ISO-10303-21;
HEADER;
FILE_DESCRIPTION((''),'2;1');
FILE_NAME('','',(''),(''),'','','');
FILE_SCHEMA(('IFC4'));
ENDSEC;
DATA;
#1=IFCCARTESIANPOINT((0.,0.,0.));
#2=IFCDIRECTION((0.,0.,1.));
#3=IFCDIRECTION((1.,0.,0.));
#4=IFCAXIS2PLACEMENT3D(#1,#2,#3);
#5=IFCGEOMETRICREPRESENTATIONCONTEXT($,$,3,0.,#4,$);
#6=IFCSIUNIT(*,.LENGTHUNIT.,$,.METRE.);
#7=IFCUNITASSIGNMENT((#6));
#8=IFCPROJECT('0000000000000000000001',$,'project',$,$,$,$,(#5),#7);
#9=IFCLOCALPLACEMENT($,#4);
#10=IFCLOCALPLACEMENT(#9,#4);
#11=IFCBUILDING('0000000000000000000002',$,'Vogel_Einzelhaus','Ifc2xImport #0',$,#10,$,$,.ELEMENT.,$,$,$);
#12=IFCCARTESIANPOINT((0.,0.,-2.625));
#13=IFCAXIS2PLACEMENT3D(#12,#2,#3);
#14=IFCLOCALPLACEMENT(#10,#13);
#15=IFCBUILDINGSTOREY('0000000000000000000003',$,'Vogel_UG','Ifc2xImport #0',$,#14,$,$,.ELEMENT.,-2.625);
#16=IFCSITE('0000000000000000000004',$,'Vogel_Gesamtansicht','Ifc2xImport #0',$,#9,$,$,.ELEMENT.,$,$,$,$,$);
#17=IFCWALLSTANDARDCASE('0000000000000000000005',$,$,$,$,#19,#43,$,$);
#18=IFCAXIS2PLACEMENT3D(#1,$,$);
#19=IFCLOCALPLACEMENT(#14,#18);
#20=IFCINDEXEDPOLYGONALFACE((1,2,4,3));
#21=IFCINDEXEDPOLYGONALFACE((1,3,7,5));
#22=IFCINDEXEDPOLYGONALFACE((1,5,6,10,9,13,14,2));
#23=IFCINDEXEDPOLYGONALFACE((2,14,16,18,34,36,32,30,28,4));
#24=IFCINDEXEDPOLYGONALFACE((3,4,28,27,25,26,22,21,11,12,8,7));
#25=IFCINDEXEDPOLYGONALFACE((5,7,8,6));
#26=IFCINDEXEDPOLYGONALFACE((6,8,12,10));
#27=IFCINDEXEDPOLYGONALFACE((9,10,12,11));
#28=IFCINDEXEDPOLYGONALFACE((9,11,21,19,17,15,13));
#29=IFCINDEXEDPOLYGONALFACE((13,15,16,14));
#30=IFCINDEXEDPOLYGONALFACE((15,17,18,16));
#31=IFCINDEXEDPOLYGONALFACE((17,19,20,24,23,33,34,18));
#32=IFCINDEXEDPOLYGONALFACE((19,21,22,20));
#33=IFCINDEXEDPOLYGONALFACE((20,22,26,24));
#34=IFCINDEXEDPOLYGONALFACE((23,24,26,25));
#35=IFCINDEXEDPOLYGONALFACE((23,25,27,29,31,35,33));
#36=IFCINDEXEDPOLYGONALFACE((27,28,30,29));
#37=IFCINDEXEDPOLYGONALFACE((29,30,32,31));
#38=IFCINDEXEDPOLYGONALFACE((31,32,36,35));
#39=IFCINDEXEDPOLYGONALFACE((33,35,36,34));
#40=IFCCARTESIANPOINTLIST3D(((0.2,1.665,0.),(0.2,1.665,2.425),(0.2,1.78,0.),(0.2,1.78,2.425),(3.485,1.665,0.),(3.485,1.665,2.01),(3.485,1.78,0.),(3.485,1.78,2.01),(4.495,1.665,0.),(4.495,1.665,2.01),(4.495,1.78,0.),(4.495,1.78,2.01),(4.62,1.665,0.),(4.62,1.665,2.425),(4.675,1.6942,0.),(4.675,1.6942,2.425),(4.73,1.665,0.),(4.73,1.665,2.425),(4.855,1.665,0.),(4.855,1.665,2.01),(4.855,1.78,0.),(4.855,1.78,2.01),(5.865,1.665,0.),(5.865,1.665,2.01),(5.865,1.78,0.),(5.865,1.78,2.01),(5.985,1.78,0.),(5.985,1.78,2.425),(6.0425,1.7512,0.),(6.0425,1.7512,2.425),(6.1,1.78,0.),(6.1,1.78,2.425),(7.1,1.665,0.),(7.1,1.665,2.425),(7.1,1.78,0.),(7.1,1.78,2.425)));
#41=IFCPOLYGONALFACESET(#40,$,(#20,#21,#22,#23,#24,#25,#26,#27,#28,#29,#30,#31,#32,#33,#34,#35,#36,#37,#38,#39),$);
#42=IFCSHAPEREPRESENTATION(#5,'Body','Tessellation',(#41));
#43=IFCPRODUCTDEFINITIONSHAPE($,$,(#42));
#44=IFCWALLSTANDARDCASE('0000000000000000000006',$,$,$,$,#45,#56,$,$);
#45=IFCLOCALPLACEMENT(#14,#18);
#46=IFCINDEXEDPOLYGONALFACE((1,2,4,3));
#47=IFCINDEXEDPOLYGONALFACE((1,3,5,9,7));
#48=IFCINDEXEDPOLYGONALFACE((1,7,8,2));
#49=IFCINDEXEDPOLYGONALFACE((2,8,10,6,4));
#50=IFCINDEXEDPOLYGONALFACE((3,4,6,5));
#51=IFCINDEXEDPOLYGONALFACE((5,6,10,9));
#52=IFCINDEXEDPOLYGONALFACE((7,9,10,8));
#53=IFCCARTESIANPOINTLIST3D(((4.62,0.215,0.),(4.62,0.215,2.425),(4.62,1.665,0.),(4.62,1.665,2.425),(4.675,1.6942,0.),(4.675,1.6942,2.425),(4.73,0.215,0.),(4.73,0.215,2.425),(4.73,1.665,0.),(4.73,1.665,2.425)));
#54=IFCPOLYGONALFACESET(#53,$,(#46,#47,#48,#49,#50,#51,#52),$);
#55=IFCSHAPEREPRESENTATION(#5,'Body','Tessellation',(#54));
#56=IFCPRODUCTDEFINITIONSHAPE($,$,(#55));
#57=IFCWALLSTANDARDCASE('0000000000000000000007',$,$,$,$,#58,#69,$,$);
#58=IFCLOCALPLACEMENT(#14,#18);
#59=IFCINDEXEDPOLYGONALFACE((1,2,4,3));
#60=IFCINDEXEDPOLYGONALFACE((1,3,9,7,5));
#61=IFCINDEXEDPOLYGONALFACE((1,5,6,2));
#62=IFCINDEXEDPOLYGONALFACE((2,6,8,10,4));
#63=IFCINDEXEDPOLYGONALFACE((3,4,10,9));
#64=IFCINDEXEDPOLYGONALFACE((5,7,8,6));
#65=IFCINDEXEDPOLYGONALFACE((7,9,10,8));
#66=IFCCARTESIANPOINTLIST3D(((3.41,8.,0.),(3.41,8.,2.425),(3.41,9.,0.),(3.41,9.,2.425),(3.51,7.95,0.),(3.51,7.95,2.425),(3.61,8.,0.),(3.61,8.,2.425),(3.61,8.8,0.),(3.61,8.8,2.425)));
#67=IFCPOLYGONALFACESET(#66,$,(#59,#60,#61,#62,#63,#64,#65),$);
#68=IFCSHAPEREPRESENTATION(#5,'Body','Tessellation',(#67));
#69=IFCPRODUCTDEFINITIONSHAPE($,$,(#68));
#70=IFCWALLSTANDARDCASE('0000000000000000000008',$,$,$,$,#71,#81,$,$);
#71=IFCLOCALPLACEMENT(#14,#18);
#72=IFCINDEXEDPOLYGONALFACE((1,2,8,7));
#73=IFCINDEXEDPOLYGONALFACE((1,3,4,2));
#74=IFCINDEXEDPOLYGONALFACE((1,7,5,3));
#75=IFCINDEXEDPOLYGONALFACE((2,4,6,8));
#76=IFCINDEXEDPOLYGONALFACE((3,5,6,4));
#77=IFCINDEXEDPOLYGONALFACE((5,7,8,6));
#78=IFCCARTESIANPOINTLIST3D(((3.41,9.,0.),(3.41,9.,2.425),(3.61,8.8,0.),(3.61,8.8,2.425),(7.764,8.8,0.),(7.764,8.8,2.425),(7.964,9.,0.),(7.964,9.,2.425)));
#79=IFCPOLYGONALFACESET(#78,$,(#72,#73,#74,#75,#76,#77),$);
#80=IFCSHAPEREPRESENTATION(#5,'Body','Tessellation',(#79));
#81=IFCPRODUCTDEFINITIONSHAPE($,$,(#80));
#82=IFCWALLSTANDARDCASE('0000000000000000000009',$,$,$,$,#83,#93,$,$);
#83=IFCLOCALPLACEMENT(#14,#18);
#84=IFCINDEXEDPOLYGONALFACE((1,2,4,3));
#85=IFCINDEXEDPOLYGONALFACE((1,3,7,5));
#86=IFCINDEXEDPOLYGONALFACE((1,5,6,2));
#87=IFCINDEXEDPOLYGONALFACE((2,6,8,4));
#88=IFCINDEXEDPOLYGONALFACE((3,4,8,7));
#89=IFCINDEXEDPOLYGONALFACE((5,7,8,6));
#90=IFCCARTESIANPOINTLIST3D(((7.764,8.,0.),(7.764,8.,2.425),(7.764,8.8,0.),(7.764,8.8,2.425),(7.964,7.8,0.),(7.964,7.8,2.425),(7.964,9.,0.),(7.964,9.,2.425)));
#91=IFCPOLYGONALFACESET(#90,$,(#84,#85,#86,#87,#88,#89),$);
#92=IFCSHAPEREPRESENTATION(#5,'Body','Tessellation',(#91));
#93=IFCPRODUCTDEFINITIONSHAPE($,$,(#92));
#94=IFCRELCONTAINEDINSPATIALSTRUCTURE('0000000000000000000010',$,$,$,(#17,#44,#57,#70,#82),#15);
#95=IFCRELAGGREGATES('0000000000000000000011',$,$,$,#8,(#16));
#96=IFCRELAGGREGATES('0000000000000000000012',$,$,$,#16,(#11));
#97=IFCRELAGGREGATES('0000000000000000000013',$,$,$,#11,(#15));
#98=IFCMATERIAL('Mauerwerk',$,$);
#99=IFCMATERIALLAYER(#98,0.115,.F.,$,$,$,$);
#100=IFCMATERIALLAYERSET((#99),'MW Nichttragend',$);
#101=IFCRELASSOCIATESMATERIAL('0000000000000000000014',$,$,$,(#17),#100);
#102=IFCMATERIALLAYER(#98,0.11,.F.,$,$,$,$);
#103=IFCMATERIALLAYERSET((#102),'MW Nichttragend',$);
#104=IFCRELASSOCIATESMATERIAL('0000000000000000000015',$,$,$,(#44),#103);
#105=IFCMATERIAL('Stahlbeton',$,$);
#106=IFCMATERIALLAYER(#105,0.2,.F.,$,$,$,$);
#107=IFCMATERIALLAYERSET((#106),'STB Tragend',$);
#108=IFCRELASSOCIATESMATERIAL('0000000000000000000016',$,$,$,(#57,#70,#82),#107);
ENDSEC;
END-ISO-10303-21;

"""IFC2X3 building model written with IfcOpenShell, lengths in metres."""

from ifc_helpers import new_model, si_unit, frame, origin_with_axes, origin_2d_with_axis, place, context, project, spatial, polyline, rectangle, outline, extrude, shape, material, layer, layer_set, layer_usage, element, save


model = new_model("IFC2X3")

# Units and contexts
context_of_model = context(None, 3, precision=0.0, world=origin_with_axes())
ifc_project = project(units=[si_unit("LENGTHUNIT", "METRE")], contexts=[context_of_model])

# Site, building, storey
site_placement = place(None, origin_with_axes())
site = spatial("IfcSite", under=ifc_project, at=site_placement, Name="Vogel_Gesamtansicht", Description="Ifc2xImport #0", CompositionType="ELEMENT")
building_placement = place(site_placement, origin_with_axes())
building = spatial("IfcBuilding", under=site, at=building_placement, Name="Vogel_Einzelhaus", Description="Ifc2xImport #0", CompositionType="ELEMENT")
storey_placement = place(building_placement, frame((0.0, 0.0, -2.625), z_axis=(0.0, 0.0, 1.0), x_axis=(1.0, 0.0, 0.0)))
storey = spatial("IfcBuildingStorey", under=building, at=storey_placement, Name="Vogel_UG", Description="Ifc2xImport #0", CompositionType="ELEMENT", Elevation=-2.625)

# Shared definitions
ifc_material_1 = material(Name="Stahlbeton")
ifc_layer_1 = layer(ifc_material_1, 0.2, ventilated=False)
ifc_layer_set_1 = layer_set([ifc_layer_1], Name="STB Tragend")
ifc_layer_usage_1 = layer_usage(ifc_layer_set_1, "AXIS2", "POSITIVE", -0.2)

# Shared definitions
ifc_material_2 = material(Name="Mauerwerk")
ifc_layer_2 = layer(ifc_material_2, 0.115, ventilated=False)
ifc_layer_set_2 = layer_set([ifc_layer_2], Name="MW Nichttragend")
ifc_layer_usage_2 = layer_usage(ifc_layer_set_2, "AXIS2", "POSITIVE", -0.115)

# Wall, openings
wall_1_placement = place(storey_placement, frame((0.2, 1.78, 0.0), z_axis=(0.0, 0.0, 1.0), x_axis=(1.0, 0.0, 0.0)))
wall_1 = element("IfcWallStandardCase", 1, at=wall_1_placement, inside=storey, material=ifc_layer_usage_2, context=context_of_model, shape_type="SweptSolid", body=[
    extrude(outline(polyline([(4.42, -0.115), (4.475, -0.0858), (4.53, -0.115), (5.8425, -0.115), (6.9, -0.115), (6.9, 0.0), (5.9, 0.0), (5.8425, -0.0288), (5.785, 0.0), (4.475, 0.0), (0.0, 0.0), (0.0, -0.115), (4.42, -0.115)])), origin_with_axes(), (0.0, 0.0, 1.0), 2.425),
])
opening_1_placement = place(wall_1_placement, frame((4.655, 0.0, 0.0), z_axis=(1.0, 0.0, 0.0), x_axis=(0.0, 0.0, 1.0)))
element("IfcOpeningElement", 2, at=opening_1_placement, cuts=wall_1, shapes=[
    shape(context_of_model, None, "SweptSolid", [extrude(rectangle(XDim=2.01, YDim=1.01, at=origin_2d_with_axis()), frame((1.005, 0.0, 0.505), z_axis=(0.0, 1.0, 0.0), x_axis=(1.0, 0.0, 0.0)), (0.0, 0.0, 1.0), 0.115)]),
])
opening_2_placement = place(wall_1_placement, frame((4.295, -0.115, 0.0), z_axis=(-1.0, 0.0, 0.0), x_axis=(0.0, 0.0, 1.0)))
element("IfcOpeningElement", 3, at=opening_2_placement, cuts=wall_1, shapes=[
    shape(context_of_model, None, "SweptSolid", [extrude(rectangle(XDim=2.01, YDim=1.01, at=origin_2d_with_axis()), frame((1.005, 0.0, 0.505), z_axis=(0.0, 1.0, 0.0), x_axis=(1.0, 0.0, 0.0)), (0.0, 0.0, 1.0), 0.115)]),
])

# Walls
ifc_layer_3 = layer(ifc_material_2, 0.11, ventilated=False)
ifc_layer_set_3 = layer_set([ifc_layer_3], Name="MW Nichttragend")
ifc_layer_usage_3 = layer_usage(ifc_layer_set_3, "AXIS2", "POSITIVE", 0.0)
wall_2_placement = place(storey_placement, frame((4.73, 0.215, 0.0), z_axis=(0.0, 0.0, 1.0), x_axis=(0.0, 1.0, 0.0)))
element("IfcWallStandardCase", 4, at=wall_2_placement, inside=storey, material=ifc_layer_usage_3, context=context_of_model, shape_type="SweptSolid", body=[
    extrude(outline(polyline([(1.45, 0.0), (1.4792, 0.055), (1.45, 0.11), (0.0, 0.11), (0.0, 0.0), (1.45, 0.0)])), origin_with_axes(), (0.0, 0.0, 1.0), 2.425),
])
wall_3_placement = place(storey_placement, frame((3.41, 8.0, 0.0), z_axis=(0.0, 0.0, 1.0), x_axis=(0.0, 1.0, 0.0)))
element("IfcWallStandardCase", 5, at=wall_3_placement, inside=storey, material=ifc_layer_usage_1, context=context_of_model, shape_type="SweptSolid", body=[
    extrude(outline(polyline([(0.0, 0.0), (-0.05, -0.1), (0.0, -0.2), (0.8, -0.2), (1.0, 0.0), (0.0, 0.0)])), origin_with_axes(), (0.0, 0.0, 1.0), 2.425),
])
wall_4_placement = place(storey_placement, frame((3.41, 9.0, 0.0), z_axis=(0.0, 0.0, 1.0), x_axis=(1.0, 0.0, 0.0)))
element("IfcWallStandardCase", 6, at=wall_4_placement, inside=storey, material=ifc_layer_usage_1, context=context_of_model, shape_type="SweptSolid", body=[
    extrude(outline(polyline([(0.0, 0.0), (0.2, -0.2), (4.354, -0.2), (4.554, 0.0), (0.0, 0.0)])), origin_with_axes(), (0.0, 0.0, 1.0), 2.425),
])
wall_5_placement = place(storey_placement, frame((7.964, 9.0, 0.0), z_axis=(0.0, 0.0, 1.0), x_axis=(0.0, -1.0, 0.0)))
element("IfcWallStandardCase", 7, at=wall_5_placement, inside=storey, material=ifc_layer_usage_1, context=context_of_model, shape_type="SweptSolid", body=[
    extrude(outline(polyline([(0.0, 0.0), (0.2, -0.2), (1.0, -0.2), (1.2, 0.0), (0.0, 0.0)])), origin_with_axes(), (0.0, 0.0, 1.0), 2.425),
])

save(model, "model.ifc")
